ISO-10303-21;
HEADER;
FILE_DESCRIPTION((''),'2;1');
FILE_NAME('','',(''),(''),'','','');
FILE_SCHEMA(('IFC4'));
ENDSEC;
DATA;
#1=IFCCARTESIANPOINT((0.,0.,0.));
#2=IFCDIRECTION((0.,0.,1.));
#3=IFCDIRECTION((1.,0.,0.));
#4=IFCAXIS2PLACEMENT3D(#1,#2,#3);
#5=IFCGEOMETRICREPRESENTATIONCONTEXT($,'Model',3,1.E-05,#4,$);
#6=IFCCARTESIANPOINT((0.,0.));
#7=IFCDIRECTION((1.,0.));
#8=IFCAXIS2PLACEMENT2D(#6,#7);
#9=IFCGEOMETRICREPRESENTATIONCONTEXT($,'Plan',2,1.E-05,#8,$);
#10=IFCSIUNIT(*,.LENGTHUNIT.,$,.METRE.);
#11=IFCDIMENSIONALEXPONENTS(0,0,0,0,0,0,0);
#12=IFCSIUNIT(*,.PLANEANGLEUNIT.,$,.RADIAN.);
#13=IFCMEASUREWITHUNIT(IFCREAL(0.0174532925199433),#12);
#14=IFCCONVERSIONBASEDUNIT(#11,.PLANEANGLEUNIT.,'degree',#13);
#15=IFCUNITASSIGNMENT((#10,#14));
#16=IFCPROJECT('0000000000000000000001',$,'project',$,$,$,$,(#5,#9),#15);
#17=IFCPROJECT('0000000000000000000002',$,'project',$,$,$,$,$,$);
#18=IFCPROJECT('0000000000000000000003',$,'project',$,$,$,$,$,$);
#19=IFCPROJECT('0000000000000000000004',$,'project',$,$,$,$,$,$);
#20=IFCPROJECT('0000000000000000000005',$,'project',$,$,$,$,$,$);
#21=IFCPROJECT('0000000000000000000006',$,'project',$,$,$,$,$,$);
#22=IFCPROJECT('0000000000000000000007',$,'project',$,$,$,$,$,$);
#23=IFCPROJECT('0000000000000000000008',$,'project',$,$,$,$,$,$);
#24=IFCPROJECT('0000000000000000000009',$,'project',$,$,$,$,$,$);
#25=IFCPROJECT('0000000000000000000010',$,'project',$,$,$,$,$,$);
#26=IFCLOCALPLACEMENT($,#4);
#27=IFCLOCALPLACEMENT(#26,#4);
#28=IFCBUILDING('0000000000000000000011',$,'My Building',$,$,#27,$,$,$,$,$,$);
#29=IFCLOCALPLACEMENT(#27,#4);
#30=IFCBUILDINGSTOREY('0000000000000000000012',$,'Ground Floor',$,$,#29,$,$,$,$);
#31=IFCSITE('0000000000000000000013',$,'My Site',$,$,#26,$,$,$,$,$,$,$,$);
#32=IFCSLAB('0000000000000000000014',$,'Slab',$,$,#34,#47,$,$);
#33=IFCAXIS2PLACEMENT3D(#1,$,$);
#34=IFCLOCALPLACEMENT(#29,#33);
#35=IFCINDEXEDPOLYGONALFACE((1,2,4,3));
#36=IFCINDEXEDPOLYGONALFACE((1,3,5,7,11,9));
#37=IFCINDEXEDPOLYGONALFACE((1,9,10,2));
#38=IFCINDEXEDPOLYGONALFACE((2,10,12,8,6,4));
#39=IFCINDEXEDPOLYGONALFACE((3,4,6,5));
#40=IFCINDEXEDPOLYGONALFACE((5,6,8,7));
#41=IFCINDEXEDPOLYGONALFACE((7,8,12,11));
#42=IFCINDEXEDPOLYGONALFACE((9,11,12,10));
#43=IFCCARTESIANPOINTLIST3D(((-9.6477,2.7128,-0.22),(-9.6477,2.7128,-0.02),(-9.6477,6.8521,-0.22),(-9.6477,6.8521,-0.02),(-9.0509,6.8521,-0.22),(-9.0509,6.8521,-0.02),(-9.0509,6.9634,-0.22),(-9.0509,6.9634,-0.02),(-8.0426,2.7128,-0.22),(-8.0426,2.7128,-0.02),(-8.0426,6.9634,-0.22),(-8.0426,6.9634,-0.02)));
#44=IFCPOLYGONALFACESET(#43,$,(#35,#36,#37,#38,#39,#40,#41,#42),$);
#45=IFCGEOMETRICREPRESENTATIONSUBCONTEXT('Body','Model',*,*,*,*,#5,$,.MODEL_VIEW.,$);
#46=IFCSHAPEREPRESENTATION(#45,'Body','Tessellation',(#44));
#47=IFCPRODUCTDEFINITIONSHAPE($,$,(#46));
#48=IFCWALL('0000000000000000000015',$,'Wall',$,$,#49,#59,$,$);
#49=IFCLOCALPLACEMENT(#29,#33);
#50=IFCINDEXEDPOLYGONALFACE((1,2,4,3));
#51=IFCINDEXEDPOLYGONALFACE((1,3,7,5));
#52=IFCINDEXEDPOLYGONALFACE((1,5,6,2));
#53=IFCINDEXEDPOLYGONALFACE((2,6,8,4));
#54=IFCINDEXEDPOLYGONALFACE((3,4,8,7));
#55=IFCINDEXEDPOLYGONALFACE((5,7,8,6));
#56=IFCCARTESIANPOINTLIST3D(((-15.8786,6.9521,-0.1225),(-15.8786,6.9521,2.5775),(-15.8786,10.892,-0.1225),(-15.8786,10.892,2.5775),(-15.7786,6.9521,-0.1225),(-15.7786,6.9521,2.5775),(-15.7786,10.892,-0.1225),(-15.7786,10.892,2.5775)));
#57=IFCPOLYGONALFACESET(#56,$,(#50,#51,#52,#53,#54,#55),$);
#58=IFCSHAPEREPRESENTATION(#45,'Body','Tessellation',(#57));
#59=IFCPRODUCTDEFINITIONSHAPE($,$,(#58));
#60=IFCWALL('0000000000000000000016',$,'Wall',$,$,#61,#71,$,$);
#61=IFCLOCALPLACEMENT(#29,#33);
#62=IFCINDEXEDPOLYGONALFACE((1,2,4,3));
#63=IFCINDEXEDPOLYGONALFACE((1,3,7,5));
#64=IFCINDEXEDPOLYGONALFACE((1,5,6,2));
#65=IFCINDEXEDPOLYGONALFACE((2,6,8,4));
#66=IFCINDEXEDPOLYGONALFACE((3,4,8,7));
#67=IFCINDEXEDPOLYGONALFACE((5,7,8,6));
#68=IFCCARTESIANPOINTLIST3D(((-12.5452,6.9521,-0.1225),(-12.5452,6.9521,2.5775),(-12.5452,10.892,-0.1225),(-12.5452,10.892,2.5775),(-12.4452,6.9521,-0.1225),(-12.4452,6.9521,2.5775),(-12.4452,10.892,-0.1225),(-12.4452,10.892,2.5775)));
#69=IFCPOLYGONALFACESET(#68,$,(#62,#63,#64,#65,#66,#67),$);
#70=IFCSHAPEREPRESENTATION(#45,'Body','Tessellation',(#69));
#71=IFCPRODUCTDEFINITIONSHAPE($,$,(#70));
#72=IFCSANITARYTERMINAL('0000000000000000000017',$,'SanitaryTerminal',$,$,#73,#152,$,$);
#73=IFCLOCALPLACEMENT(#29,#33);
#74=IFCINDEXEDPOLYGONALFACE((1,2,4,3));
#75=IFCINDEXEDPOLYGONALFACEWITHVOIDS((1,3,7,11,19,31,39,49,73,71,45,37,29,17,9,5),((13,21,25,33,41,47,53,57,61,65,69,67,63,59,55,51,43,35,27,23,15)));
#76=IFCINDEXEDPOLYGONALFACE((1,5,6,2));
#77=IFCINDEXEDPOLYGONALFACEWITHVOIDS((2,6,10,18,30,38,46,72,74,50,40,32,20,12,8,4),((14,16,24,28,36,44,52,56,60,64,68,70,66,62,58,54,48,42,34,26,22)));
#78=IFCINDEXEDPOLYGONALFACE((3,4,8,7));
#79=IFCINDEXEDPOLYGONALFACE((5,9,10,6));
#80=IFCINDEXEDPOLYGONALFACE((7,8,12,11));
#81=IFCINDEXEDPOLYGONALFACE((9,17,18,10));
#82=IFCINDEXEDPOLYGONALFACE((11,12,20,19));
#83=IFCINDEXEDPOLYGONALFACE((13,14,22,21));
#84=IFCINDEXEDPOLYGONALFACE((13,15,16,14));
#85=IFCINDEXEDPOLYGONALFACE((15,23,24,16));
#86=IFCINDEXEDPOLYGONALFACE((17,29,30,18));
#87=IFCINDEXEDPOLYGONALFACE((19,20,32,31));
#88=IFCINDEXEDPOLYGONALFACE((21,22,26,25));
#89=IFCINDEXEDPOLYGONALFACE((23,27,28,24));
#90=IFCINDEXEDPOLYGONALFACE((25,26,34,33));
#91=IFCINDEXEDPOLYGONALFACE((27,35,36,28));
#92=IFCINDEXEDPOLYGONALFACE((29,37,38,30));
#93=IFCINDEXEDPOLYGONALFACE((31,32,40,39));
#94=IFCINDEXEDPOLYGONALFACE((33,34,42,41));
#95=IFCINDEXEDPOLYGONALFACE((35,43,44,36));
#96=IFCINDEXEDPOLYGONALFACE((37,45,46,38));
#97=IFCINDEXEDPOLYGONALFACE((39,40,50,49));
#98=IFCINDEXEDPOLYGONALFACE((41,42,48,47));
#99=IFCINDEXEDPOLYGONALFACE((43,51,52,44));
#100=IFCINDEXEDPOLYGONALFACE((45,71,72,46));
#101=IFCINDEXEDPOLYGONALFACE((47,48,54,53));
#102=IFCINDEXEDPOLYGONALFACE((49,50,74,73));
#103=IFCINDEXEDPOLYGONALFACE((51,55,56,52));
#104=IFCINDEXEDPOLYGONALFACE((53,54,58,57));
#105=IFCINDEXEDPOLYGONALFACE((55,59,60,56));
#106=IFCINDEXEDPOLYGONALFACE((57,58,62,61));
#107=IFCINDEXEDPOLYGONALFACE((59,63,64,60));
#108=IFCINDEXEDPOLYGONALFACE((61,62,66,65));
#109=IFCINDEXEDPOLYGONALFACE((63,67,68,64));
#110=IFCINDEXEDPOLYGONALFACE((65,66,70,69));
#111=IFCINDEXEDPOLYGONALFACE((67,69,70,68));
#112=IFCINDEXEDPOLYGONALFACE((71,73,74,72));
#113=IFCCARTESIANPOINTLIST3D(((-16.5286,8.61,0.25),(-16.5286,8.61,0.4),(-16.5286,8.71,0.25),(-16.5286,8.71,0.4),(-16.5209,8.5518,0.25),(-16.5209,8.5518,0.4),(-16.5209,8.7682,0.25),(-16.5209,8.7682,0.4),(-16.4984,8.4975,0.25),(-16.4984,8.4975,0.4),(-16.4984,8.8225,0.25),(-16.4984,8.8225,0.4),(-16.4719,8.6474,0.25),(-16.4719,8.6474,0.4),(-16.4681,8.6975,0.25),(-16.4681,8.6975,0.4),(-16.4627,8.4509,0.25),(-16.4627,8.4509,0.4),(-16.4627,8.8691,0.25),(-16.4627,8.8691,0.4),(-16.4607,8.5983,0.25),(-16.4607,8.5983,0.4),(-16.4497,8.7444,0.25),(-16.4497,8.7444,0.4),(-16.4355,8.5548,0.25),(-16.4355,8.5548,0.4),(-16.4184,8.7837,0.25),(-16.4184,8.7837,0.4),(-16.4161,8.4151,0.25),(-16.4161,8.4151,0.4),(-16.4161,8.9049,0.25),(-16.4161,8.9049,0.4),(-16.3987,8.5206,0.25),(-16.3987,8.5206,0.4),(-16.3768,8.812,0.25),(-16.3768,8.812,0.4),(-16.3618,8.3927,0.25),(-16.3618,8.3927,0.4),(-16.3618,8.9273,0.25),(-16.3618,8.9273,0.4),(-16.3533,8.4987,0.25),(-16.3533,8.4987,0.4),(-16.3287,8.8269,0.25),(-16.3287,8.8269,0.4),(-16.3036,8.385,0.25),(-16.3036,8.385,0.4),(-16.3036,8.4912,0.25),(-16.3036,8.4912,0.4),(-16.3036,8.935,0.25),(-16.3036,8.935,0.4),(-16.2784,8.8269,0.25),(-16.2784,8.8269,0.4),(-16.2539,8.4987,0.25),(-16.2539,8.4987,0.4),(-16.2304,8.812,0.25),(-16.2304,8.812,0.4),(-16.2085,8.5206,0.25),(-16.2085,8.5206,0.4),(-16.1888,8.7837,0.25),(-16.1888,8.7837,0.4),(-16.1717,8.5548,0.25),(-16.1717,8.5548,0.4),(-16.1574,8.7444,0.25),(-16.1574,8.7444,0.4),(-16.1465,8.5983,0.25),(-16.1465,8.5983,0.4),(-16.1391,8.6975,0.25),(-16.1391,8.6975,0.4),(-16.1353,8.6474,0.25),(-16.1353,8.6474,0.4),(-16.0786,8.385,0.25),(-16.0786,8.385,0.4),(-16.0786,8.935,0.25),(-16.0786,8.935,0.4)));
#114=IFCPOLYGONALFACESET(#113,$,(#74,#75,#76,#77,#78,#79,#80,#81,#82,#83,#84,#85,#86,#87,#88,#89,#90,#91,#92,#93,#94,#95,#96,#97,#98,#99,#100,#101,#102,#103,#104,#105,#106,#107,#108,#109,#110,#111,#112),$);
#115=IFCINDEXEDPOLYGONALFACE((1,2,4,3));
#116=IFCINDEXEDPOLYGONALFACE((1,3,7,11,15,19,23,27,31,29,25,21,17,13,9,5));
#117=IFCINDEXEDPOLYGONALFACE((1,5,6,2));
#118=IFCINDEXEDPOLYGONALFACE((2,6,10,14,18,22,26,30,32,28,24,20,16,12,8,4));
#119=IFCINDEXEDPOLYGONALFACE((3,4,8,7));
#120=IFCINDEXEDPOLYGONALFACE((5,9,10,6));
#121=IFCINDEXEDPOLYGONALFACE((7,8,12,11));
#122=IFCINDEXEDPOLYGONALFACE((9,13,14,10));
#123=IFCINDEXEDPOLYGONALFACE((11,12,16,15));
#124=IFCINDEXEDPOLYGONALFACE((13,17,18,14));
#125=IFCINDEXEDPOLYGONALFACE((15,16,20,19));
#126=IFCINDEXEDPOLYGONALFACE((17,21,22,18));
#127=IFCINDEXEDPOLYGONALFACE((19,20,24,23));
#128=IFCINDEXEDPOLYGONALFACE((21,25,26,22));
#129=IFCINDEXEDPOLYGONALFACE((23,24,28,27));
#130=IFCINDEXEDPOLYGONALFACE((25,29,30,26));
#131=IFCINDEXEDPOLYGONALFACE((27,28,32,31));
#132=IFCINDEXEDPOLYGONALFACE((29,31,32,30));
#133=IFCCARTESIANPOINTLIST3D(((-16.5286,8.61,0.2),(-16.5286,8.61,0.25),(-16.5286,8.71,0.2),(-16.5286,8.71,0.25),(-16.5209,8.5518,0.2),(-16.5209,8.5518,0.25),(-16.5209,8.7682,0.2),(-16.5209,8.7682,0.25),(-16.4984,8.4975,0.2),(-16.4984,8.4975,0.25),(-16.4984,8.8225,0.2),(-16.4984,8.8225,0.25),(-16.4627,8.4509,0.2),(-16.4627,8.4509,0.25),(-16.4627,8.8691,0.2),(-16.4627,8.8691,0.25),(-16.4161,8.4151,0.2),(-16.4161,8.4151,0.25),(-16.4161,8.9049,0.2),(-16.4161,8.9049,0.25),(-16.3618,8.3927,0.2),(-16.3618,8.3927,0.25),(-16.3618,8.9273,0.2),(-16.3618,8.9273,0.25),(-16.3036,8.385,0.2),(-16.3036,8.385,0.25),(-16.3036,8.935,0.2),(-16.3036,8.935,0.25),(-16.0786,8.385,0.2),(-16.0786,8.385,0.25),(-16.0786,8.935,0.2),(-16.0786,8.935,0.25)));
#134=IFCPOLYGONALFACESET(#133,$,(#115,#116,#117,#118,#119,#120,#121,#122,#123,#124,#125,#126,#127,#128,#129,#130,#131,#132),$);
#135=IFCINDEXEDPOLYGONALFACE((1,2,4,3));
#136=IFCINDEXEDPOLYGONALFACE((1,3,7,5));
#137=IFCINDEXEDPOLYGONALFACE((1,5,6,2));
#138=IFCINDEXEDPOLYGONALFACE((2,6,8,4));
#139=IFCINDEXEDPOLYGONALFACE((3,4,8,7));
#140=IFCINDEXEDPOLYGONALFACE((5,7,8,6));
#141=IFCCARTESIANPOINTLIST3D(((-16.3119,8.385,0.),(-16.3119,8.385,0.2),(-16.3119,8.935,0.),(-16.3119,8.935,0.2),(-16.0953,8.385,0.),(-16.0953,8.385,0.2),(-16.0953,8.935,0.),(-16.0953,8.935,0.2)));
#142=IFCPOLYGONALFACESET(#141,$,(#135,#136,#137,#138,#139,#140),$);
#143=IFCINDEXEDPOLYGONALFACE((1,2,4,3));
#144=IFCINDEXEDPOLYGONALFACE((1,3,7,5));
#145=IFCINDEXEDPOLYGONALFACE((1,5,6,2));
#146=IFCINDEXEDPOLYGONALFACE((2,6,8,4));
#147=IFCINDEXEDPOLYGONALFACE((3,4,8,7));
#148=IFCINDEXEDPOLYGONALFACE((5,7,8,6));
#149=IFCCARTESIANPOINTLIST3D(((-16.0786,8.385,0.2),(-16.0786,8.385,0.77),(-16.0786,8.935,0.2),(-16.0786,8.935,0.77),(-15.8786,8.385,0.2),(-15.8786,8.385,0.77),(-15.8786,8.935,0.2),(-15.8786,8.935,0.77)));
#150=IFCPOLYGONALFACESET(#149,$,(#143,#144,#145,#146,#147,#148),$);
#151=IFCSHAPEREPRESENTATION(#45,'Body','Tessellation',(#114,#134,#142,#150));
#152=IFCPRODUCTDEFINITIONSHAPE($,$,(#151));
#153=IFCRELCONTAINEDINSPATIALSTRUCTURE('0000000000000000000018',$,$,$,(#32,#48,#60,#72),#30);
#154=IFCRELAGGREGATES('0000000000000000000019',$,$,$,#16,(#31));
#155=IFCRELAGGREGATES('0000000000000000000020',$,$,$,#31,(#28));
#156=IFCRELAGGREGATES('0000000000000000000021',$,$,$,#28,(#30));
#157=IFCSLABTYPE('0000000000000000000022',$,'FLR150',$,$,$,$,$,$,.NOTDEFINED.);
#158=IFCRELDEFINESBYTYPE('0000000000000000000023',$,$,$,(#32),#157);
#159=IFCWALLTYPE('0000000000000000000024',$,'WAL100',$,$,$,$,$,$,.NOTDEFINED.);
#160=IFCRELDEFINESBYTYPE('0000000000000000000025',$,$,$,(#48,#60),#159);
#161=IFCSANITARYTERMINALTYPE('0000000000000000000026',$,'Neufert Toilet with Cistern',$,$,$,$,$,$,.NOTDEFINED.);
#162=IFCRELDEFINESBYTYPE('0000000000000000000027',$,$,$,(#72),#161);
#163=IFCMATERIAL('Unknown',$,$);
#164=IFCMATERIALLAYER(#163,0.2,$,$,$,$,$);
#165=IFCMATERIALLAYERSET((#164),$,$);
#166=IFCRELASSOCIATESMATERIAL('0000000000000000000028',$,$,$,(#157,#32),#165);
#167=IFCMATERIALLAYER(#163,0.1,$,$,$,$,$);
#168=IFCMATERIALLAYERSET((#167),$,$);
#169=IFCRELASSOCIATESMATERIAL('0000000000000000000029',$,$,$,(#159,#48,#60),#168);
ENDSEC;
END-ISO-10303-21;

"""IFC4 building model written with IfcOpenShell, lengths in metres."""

from ifc_helpers import new_model, entity, si_unit, converted_unit, frame, frame_2d, origin_with_axes, origin_2d_with_axis, place, context, subcontext, project, spatial, line, arc, indexed_curve, circle_curve, outline, extrude, shape, source, transform, mapped, material, layer, layer_set, layer_usage, type_object, type_shapes, element, save


model = new_model("IFC4")

# Units and contexts
model_context = context("Model", 3, precision=1e-05, world=origin_with_axes())
plan_context = context("Plan", 2, precision=1e-05, world=origin_2d_with_axis())
body_context_1 = subcontext(model_context, "Body", "Model", "MODEL_VIEW")
body_context_2 = subcontext(plan_context, "Body", "Plan", "PLAN_VIEW")
ifc_project_1 = project(units=[si_unit("LENGTHUNIT", "METRE"), converted_unit("PLANEANGLEUNIT", "degree", entity("IfcReal", 0.0174532925199433), si_unit("PLANEANGLEUNIT", "RADIAN"), dimensions=[0, 0, 0, 0, 0, 0, 0])], contexts=[model_context, plan_context])
ifc_project_2 = project()
ifc_project_3 = project()
ifc_project_4 = project()
ifc_project_5 = project()
ifc_project_6 = project()
ifc_project_7 = project()
ifc_project_8 = project()
ifc_project_9 = project()
ifc_project_10 = project()

# Site, building, storey
site_placement = place(None, origin_with_axes())
site = spatial("IfcSite", under=ifc_project_1, at=site_placement, Name="My Site")
building_placement = place(site_placement, origin_with_axes())
building = spatial("IfcBuilding", under=site, at=building_placement, Name="My Building")
storey_placement = place(building_placement, origin_with_axes())
storey = spatial("IfcBuildingStorey", under=building, at=storey_placement, Name="Ground Floor")

# Slab
ifc_material = material(Name="Unknown")
ifc_layer_1 = layer(ifc_material, 0.2)
ifc_layer_set_1 = layer_set([ifc_layer_1])
ifc_layer_usage_1 = layer_usage(ifc_layer_set_1, "AXIS3", "POSITIVE", 0.0)
slab_type = type_object("IfcSlabType", Name="FLR150", PredefinedType="NOTDEFINED", material=ifc_layer_set_1)
slab_placement = place(storey_placement, frame((-9.6477, 2.7128, -0.22), z_axis=(0.0, 0.0, 1.0), x_axis=(1.0, 0.0, 0.0)))
element("IfcSlab", 1, at=slab_placement, inside=storey, type_object=slab_type, material=ifc_layer_usage_1, Name="Slab", context=body_context_1, shape_type="SweptSolid", body=[
    extrude(outline(indexed_curve([(0.0, 0.0), (1.6052, 0.0), (1.6052, 4.2506), (0.5969, 4.1393), (0.0, 4.1393), (0.5969, 4.2506)], segments=[line(6, 4), line(4, 5), line(5, 1), line(1, 2), line(2, 3), line(3, 6)], self_intersect=False)), None, (0.0, 0.0, 1.0), 0.2),
])

# Shared definitions
ifc_layer_2 = layer(ifc_material, 0.1)
ifc_layer_set_2 = layer_set([ifc_layer_2])
wall_type = type_object("IfcWallType", Name="WAL100", PredefinedType="NOTDEFINED", material=ifc_layer_set_2)

# Walls
ifc_layer_usage_2 = layer_usage(ifc_layer_set_2, "AXIS2", "POSITIVE", 0.0)
wall_1_placement = place(storey_placement, frame((-15.8786, 10.892, -0.1225), z_axis=(0.0, 0.0, 1.0), x_axis=(-0.000001, -1.0, 0.0)))
element("IfcWall", 2, at=wall_1_placement, inside=storey, type_object=wall_type, material=ifc_layer_usage_2, Name="Wall", context=body_context_1, shape_type="SweptSolid", body=[
    extrude(outline(indexed_curve([(0.0, 0.0), (0.0, 0.1), (3.9399, 0.1), (3.9399, 0.0), (0.0, 0.0)], self_intersect=False)), origin_with_axes(), (0.0, 0.0, 1.0), 2.7),
])
ifc_layer_usage_3 = layer_usage(ifc_layer_set_2, "AXIS2", "POSITIVE", 0.0)
wall_2_placement = place(storey_placement, frame((-12.5452, 10.892, -0.1225), z_axis=(0.0, 0.0, 1.0), x_axis=(-0.000001, -1.0, 0.0)))
element("IfcWall", 3, at=wall_2_placement, inside=storey, type_object=wall_type, material=ifc_layer_usage_3, Name="Wall", context=body_context_1, shape_type="SweptSolid", body=[
    extrude(outline(indexed_curve([(0.0, 0.0), (0.0, 0.1), (3.9399, 0.1), (3.9399, 0.0), (0.0, 0.0)], self_intersect=False)), origin_with_axes(), (0.0, 0.0, 1.0), 2.7),
])

# Sanitary terminal
sanitary_terminal_type_1 = type_object("IfcSanitaryTerminalType", Name="Neufert Toilet with Cistern", PredefinedType="NOTDEFINED")
shared_shape_1 = source(origin_with_axes(), body_context_1, "Body", "SweptSolid", [
    extrude(outline(indexed_curve([(-0.275, -0.2), (0.275, -0.2), (0.275, -0.425), (0.2091, -0.5841), (0.05, -0.65), (-0.05, -0.65), (-0.2091, -0.5841), (-0.275, -0.425)], segments=[line(1, 2), line(2, 3), arc(3, 4, 5), line(5, 6), arc(6, 7, 8), line(8, 1)]), holes=[circle_curve(frame_2d((0.0, -0.425)), 0.1688)]), frame((0.0, 0.0, 0.25), z_axis=(0.0, 0.0, 1.0), x_axis=(1.0, 0.0, 0.0)), (0.0, 0.0, 1.0), 0.15),
    extrude(outline(indexed_curve([(-0.275, -0.2), (0.275, -0.2), (0.275, -0.425), (0.2091, -0.5841), (0.05, -0.65), (-0.05, -0.65), (-0.2091, -0.5841), (-0.275, -0.425)], segments=[line(1, 2), line(2, 3), arc(3, 4, 5), line(5, 6), arc(6, 7, 8), line(8, 1)])), frame((0.0, 0.0, 0.2), z_axis=(0.0, 0.0, 1.0), x_axis=(1.0, 0.0, 0.0)), (0.0, 0.0, 1.0), 0.05),
    extrude(outline(indexed_curve([(-0.275, -0.2167), (0.275, -0.2167), (0.275, -0.4333), (-0.275, -0.4333)], segments=[line(1, 2), line(2, 3), line(3, 4), line(4, 1)])), origin_with_axes(), (0.0, 0.0, 1.0), 0.2),
    extrude(outline(indexed_curve([(-0.275, 0.0), (0.275, 0.0), (0.275, -0.2), (-0.275, -0.2)], segments=[line(1, 2), line(2, 3), line(3, 4), line(4, 1)])), frame((0.0, 0.0, 0.2), z_axis=(0.0, 0.0, 1.0), x_axis=(1.0, 0.0, 0.0)), (0.0, 0.0, 1.0), 0.57),
])
shared_shape_2 = source(origin_with_axes(), body_context_2, "Body", "Curve2D", [
    entity("IfcIndexedPolyCurve", entity("IfcCartesianPointList2D", [[-0.275, 0.0], [0.275, 0.0], [0.275, -0.2], [-0.275, -0.2]]), [entity("IfcLineIndex", [1, 2]), entity("IfcLineIndex", [2, 3]), entity("IfcLineIndex", [3, 4]), entity("IfcLineIndex", [4, 1])]),
    entity("IfcIndexedPolyCurve", entity("IfcCartesianPointList2D", [[0.165, -0.2], [0.1925, -0.335]]), [entity("IfcLineIndex", [1, 2])]),
    entity("IfcTrimmedCurve", entity("IfcEllipse", entity("IfcAxis2Placement2D", entity("IfcCartesianPoint", [0.0, -0.335]), entity("IfcDirection", [1.0, 0.0])), 0.1925, 0.315), [entity("IfcCartesianPoint", [-0.1925, -0.335])], [entity("IfcCartesianPoint", [0.1925, -0.335])], True, "CARTESIAN"),
    entity("IfcIndexedPolyCurve", entity("IfcCartesianPointList2D", [[-0.165, -0.2], [-0.1925, -0.335]]), [entity("IfcLineIndex", [1, 2])]),
    entity("IfcEllipse", entity("IfcAxis2Placement2D", entity("IfcCartesianPoint", [0.0, -0.452]), entity("IfcDirection", [1.0, 0.0])), 0.1313, 0.1575),
    entity("IfcIndexedPolyCurve", entity("IfcCartesianPointList2D", [[-0.0344, -0.452], [-0.0344, -0.4295], [0.0344, -0.4295], [0.0344, -0.452]]), [entity("IfcLineIndex", [1, 2]), entity("IfcLineIndex", [2, 3]), entity("IfcLineIndex", [3, 4])]),
    entity("IfcTrimmedCurve", entity("IfcEllipse", entity("IfcAxis2Placement2D", entity("IfcCartesianPoint", [0.0, -0.452]), entity("IfcDirection", [1.0, 0.0])), 0.0344, 0.0225), [entity("IfcCartesianPoint", [-0.0344, -0.452])], [entity("IfcCartesianPoint", [0.0344, -0.452])], True, "CARTESIAN"),
])
type_shapes(sanitary_terminal_type_1, [shared_shape_1, shared_shape_2])
sanitary_terminal_1_placement = place(storey_placement, frame((-15.8786, 8.66, 0.0), z_axis=(0.0, 0.0, 1.0), x_axis=(0.0, -1.0, 0.0)))
element("IfcSanitaryTerminal", 4, at=sanitary_terminal_1_placement, inside=storey, type_object=sanitary_terminal_type_1, Name="SanitaryTerminal", shapes=[
    shape(body_context_1, "Body", "MappedRepresentation", [mapped(shared_shape_1, transform((0.0, 0.0, 0.0), x_axis=(1.0, 0.0, 0.0), y_axis=(0.0, 1.0, 0.0), z_axis=(0.0, 0.0, 1.0), scale=1.0))]),
    shape(body_context_2, "Body", "MappedRepresentation", [mapped(shared_shape_2, transform((0.0, 0.0, 0.0), x_axis=(1.0, 0.0, 0.0), y_axis=(0.0, 1.0, 0.0), z_axis=(0.0, 0.0, 1.0), scale=1.0))]),
])

save(model, "model.ifc")
